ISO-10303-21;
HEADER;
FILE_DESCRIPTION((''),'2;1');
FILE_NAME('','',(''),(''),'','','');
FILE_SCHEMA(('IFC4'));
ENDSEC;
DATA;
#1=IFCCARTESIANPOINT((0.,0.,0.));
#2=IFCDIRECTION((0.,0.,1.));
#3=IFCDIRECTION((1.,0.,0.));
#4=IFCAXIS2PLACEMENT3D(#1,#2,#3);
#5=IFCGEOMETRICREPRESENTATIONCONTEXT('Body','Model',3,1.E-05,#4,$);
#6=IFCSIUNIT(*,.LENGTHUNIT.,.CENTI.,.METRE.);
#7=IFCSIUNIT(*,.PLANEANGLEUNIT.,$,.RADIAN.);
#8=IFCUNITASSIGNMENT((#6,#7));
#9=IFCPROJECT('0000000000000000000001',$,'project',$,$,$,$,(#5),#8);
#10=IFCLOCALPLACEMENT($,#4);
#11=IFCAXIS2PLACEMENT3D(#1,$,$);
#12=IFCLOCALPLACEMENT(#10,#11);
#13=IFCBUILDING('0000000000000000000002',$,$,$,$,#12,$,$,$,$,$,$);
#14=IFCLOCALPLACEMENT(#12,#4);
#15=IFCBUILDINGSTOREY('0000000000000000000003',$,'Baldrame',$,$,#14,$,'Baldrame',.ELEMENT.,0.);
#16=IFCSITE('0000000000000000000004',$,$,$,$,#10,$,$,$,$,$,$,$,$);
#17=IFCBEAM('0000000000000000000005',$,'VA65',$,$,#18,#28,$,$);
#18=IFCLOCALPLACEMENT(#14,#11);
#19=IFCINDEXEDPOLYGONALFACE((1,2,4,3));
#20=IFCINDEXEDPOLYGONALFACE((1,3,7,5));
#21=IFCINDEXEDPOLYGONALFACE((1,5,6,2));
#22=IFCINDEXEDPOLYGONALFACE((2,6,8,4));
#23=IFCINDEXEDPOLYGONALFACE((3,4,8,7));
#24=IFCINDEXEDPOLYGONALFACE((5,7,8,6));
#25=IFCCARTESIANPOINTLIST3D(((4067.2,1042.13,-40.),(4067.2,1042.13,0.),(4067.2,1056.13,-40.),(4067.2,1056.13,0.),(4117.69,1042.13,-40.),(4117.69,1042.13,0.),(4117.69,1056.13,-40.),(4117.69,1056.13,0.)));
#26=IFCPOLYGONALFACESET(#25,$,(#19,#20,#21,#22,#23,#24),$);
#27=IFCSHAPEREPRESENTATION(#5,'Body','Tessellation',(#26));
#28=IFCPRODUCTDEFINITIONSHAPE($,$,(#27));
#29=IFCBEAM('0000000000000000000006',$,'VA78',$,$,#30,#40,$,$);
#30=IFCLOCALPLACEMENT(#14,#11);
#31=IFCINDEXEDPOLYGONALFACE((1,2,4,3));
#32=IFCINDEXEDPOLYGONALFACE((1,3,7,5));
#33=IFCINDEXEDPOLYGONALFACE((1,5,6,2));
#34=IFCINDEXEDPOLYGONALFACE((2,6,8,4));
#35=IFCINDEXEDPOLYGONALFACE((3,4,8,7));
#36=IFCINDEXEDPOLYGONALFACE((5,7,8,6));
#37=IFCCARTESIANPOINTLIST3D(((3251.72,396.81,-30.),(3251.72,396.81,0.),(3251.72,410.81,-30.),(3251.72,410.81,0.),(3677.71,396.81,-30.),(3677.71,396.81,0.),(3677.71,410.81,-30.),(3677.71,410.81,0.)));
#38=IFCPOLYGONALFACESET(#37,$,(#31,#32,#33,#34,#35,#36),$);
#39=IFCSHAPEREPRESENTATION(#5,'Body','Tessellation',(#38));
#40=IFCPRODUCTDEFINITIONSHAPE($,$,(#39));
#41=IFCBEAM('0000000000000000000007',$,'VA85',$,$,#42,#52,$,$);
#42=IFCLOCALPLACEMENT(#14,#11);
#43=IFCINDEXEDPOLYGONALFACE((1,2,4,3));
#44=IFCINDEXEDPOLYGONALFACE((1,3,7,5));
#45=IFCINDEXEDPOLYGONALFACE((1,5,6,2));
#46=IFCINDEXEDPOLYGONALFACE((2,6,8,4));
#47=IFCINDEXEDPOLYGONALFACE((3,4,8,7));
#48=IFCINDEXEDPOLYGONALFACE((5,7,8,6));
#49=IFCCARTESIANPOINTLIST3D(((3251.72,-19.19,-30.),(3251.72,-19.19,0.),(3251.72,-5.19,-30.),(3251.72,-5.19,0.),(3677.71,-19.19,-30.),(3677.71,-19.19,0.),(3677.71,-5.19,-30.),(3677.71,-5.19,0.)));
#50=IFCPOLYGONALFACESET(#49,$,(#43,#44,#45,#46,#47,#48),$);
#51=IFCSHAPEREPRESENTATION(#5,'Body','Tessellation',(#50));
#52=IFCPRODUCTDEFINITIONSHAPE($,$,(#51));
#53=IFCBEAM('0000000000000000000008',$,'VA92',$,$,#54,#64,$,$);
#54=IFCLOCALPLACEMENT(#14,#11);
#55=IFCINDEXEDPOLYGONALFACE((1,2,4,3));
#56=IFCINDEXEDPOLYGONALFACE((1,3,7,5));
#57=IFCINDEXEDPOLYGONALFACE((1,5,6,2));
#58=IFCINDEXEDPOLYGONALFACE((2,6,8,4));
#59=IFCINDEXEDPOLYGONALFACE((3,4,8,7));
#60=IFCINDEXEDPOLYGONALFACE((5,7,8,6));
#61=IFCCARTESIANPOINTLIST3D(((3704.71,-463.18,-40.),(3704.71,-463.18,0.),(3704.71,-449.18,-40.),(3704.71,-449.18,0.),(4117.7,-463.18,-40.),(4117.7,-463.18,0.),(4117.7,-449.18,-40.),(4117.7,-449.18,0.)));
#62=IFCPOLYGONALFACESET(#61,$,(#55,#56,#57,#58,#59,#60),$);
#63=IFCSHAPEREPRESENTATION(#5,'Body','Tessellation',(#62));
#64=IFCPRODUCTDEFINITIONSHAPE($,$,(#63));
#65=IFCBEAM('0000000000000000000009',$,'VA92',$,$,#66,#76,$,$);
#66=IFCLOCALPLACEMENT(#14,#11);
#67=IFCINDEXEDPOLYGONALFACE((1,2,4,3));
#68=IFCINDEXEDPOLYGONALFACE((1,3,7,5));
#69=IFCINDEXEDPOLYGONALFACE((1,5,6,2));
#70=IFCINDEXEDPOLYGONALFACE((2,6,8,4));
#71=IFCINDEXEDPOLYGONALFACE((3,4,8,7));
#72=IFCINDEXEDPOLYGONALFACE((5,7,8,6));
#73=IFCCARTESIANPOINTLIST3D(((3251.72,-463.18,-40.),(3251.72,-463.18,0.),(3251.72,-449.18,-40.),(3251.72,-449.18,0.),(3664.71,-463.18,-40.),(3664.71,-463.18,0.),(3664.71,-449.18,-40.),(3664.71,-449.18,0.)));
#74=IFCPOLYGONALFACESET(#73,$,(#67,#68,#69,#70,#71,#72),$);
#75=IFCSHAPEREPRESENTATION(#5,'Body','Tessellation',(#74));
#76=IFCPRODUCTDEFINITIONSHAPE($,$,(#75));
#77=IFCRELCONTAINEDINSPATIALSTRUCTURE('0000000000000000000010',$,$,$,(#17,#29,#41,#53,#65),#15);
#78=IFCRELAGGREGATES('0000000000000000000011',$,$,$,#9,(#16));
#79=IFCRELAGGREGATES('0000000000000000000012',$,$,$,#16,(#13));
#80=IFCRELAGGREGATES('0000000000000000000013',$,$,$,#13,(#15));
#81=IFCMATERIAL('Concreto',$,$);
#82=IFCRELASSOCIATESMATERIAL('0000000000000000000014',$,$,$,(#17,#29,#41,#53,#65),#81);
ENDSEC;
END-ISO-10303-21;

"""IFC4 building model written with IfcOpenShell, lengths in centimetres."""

from ifc_helpers import new_model, si_unit, frame, origin, origin_with_axes, origin_2d_with_axis, place, context, project, spatial, rectangle, extrude, material, element, save


model = new_model("IFC4")

# Units and contexts
model_context = context("Model", 3, precision=1e-05, world=origin_with_axes(), identifier="Body")
ifc_project = project(units=[si_unit("LENGTHUNIT", "METRE", prefix="CENTI"), si_unit("PLANEANGLEUNIT", "RADIAN")], contexts=[model_context])

# Site, building, storey
site_placement = place(None, origin_with_axes())
site = spatial("IfcSite", under=ifc_project, at=site_placement)
building_placement = place(site_placement, origin())
building = spatial("IfcBuilding", under=site, at=building_placement)
storey_placement = place(building_placement, origin_with_axes())
storey = spatial("IfcBuildingStorey", under=building, at=storey_placement, Name="Baldrame", LongName="Baldrame", CompositionType="ELEMENT", Elevation=0.0)

# Shared definitions
ifc_material = material(Name="Concreto")

# Beams
beam_1_placement = place(storey_placement, frame((4092.45, 1049.13, 0.0), z_axis=(0.0, 0.0, 1.0), x_axis=(1.0, 0.0, 0.0)))
element("IfcBeam", 1, at=beam_1_placement, inside=storey, material=ifc_material, Name="VA65", context=model_context, shape_type="SolidModel", body=[
    extrude(rectangle(XDim=14.0, YDim=40.0, at=origin_2d_with_axis()), frame((-25.25, 0.0, -20.0), z_axis=(1.0, 0.0, 0.0), x_axis=(0.0, 1.0, 0.0)), (0.0, 0.0, 1.0), 50.49),
])
for number, where, z_axis, x_axis, name in (
    (2, (3464.72, 403.81, 0.0), (0.0, 0.0, 1.0), (1.0, 0.0, 0.0), "VA78"),
    (3, (3464.72, -12.19, 0.0), (0.0, 0.0, 1.0), (1.0, 0.0, 0.0), "VA85"),
):
    element("IfcBeam", number, at=place(storey_placement, frame(where, z_axis=z_axis, x_axis=x_axis)), inside=storey, material=ifc_material, Name=name, context=model_context, shape_type="SolidModel", body=[
        extrude(rectangle(XDim=14.0, YDim=30.0, at=origin_2d_with_axis()), frame((-213.0, 0.0, -15.0), z_axis=(1.0, 0.0, 0.0), x_axis=(0.0, 1.0, 0.0)), (0.0, 0.0, 1.0), 425.99),
    ])
for number, where, z_axis, x_axis, name in (
    (4, (3911.2, -456.18, 0.0), (0.0, 0.0, 1.0), (1.0, 0.0, 0.0), "VA92"),
    (5, (3458.22, -456.18, 0.0), (0.0, 0.0, 1.0), (1.0, 0.0, 0.0), "VA92"),
):
    element("IfcBeam", number, at=place(storey_placement, frame(where, z_axis=z_axis, x_axis=x_axis)), inside=storey, material=ifc_material, Name=name, context=model_context, shape_type="SolidModel", body=[
        extrude(rectangle(XDim=14.0, YDim=40.0, at=origin_2d_with_axis()), frame((-206.5, 0.0, -20.0), z_axis=(1.0, 0.0, 0.0), x_axis=(0.0, 1.0, 0.0)), (0.0, 0.0, 1.0), 412.99),
    ])

save(model, "model.ifc")
